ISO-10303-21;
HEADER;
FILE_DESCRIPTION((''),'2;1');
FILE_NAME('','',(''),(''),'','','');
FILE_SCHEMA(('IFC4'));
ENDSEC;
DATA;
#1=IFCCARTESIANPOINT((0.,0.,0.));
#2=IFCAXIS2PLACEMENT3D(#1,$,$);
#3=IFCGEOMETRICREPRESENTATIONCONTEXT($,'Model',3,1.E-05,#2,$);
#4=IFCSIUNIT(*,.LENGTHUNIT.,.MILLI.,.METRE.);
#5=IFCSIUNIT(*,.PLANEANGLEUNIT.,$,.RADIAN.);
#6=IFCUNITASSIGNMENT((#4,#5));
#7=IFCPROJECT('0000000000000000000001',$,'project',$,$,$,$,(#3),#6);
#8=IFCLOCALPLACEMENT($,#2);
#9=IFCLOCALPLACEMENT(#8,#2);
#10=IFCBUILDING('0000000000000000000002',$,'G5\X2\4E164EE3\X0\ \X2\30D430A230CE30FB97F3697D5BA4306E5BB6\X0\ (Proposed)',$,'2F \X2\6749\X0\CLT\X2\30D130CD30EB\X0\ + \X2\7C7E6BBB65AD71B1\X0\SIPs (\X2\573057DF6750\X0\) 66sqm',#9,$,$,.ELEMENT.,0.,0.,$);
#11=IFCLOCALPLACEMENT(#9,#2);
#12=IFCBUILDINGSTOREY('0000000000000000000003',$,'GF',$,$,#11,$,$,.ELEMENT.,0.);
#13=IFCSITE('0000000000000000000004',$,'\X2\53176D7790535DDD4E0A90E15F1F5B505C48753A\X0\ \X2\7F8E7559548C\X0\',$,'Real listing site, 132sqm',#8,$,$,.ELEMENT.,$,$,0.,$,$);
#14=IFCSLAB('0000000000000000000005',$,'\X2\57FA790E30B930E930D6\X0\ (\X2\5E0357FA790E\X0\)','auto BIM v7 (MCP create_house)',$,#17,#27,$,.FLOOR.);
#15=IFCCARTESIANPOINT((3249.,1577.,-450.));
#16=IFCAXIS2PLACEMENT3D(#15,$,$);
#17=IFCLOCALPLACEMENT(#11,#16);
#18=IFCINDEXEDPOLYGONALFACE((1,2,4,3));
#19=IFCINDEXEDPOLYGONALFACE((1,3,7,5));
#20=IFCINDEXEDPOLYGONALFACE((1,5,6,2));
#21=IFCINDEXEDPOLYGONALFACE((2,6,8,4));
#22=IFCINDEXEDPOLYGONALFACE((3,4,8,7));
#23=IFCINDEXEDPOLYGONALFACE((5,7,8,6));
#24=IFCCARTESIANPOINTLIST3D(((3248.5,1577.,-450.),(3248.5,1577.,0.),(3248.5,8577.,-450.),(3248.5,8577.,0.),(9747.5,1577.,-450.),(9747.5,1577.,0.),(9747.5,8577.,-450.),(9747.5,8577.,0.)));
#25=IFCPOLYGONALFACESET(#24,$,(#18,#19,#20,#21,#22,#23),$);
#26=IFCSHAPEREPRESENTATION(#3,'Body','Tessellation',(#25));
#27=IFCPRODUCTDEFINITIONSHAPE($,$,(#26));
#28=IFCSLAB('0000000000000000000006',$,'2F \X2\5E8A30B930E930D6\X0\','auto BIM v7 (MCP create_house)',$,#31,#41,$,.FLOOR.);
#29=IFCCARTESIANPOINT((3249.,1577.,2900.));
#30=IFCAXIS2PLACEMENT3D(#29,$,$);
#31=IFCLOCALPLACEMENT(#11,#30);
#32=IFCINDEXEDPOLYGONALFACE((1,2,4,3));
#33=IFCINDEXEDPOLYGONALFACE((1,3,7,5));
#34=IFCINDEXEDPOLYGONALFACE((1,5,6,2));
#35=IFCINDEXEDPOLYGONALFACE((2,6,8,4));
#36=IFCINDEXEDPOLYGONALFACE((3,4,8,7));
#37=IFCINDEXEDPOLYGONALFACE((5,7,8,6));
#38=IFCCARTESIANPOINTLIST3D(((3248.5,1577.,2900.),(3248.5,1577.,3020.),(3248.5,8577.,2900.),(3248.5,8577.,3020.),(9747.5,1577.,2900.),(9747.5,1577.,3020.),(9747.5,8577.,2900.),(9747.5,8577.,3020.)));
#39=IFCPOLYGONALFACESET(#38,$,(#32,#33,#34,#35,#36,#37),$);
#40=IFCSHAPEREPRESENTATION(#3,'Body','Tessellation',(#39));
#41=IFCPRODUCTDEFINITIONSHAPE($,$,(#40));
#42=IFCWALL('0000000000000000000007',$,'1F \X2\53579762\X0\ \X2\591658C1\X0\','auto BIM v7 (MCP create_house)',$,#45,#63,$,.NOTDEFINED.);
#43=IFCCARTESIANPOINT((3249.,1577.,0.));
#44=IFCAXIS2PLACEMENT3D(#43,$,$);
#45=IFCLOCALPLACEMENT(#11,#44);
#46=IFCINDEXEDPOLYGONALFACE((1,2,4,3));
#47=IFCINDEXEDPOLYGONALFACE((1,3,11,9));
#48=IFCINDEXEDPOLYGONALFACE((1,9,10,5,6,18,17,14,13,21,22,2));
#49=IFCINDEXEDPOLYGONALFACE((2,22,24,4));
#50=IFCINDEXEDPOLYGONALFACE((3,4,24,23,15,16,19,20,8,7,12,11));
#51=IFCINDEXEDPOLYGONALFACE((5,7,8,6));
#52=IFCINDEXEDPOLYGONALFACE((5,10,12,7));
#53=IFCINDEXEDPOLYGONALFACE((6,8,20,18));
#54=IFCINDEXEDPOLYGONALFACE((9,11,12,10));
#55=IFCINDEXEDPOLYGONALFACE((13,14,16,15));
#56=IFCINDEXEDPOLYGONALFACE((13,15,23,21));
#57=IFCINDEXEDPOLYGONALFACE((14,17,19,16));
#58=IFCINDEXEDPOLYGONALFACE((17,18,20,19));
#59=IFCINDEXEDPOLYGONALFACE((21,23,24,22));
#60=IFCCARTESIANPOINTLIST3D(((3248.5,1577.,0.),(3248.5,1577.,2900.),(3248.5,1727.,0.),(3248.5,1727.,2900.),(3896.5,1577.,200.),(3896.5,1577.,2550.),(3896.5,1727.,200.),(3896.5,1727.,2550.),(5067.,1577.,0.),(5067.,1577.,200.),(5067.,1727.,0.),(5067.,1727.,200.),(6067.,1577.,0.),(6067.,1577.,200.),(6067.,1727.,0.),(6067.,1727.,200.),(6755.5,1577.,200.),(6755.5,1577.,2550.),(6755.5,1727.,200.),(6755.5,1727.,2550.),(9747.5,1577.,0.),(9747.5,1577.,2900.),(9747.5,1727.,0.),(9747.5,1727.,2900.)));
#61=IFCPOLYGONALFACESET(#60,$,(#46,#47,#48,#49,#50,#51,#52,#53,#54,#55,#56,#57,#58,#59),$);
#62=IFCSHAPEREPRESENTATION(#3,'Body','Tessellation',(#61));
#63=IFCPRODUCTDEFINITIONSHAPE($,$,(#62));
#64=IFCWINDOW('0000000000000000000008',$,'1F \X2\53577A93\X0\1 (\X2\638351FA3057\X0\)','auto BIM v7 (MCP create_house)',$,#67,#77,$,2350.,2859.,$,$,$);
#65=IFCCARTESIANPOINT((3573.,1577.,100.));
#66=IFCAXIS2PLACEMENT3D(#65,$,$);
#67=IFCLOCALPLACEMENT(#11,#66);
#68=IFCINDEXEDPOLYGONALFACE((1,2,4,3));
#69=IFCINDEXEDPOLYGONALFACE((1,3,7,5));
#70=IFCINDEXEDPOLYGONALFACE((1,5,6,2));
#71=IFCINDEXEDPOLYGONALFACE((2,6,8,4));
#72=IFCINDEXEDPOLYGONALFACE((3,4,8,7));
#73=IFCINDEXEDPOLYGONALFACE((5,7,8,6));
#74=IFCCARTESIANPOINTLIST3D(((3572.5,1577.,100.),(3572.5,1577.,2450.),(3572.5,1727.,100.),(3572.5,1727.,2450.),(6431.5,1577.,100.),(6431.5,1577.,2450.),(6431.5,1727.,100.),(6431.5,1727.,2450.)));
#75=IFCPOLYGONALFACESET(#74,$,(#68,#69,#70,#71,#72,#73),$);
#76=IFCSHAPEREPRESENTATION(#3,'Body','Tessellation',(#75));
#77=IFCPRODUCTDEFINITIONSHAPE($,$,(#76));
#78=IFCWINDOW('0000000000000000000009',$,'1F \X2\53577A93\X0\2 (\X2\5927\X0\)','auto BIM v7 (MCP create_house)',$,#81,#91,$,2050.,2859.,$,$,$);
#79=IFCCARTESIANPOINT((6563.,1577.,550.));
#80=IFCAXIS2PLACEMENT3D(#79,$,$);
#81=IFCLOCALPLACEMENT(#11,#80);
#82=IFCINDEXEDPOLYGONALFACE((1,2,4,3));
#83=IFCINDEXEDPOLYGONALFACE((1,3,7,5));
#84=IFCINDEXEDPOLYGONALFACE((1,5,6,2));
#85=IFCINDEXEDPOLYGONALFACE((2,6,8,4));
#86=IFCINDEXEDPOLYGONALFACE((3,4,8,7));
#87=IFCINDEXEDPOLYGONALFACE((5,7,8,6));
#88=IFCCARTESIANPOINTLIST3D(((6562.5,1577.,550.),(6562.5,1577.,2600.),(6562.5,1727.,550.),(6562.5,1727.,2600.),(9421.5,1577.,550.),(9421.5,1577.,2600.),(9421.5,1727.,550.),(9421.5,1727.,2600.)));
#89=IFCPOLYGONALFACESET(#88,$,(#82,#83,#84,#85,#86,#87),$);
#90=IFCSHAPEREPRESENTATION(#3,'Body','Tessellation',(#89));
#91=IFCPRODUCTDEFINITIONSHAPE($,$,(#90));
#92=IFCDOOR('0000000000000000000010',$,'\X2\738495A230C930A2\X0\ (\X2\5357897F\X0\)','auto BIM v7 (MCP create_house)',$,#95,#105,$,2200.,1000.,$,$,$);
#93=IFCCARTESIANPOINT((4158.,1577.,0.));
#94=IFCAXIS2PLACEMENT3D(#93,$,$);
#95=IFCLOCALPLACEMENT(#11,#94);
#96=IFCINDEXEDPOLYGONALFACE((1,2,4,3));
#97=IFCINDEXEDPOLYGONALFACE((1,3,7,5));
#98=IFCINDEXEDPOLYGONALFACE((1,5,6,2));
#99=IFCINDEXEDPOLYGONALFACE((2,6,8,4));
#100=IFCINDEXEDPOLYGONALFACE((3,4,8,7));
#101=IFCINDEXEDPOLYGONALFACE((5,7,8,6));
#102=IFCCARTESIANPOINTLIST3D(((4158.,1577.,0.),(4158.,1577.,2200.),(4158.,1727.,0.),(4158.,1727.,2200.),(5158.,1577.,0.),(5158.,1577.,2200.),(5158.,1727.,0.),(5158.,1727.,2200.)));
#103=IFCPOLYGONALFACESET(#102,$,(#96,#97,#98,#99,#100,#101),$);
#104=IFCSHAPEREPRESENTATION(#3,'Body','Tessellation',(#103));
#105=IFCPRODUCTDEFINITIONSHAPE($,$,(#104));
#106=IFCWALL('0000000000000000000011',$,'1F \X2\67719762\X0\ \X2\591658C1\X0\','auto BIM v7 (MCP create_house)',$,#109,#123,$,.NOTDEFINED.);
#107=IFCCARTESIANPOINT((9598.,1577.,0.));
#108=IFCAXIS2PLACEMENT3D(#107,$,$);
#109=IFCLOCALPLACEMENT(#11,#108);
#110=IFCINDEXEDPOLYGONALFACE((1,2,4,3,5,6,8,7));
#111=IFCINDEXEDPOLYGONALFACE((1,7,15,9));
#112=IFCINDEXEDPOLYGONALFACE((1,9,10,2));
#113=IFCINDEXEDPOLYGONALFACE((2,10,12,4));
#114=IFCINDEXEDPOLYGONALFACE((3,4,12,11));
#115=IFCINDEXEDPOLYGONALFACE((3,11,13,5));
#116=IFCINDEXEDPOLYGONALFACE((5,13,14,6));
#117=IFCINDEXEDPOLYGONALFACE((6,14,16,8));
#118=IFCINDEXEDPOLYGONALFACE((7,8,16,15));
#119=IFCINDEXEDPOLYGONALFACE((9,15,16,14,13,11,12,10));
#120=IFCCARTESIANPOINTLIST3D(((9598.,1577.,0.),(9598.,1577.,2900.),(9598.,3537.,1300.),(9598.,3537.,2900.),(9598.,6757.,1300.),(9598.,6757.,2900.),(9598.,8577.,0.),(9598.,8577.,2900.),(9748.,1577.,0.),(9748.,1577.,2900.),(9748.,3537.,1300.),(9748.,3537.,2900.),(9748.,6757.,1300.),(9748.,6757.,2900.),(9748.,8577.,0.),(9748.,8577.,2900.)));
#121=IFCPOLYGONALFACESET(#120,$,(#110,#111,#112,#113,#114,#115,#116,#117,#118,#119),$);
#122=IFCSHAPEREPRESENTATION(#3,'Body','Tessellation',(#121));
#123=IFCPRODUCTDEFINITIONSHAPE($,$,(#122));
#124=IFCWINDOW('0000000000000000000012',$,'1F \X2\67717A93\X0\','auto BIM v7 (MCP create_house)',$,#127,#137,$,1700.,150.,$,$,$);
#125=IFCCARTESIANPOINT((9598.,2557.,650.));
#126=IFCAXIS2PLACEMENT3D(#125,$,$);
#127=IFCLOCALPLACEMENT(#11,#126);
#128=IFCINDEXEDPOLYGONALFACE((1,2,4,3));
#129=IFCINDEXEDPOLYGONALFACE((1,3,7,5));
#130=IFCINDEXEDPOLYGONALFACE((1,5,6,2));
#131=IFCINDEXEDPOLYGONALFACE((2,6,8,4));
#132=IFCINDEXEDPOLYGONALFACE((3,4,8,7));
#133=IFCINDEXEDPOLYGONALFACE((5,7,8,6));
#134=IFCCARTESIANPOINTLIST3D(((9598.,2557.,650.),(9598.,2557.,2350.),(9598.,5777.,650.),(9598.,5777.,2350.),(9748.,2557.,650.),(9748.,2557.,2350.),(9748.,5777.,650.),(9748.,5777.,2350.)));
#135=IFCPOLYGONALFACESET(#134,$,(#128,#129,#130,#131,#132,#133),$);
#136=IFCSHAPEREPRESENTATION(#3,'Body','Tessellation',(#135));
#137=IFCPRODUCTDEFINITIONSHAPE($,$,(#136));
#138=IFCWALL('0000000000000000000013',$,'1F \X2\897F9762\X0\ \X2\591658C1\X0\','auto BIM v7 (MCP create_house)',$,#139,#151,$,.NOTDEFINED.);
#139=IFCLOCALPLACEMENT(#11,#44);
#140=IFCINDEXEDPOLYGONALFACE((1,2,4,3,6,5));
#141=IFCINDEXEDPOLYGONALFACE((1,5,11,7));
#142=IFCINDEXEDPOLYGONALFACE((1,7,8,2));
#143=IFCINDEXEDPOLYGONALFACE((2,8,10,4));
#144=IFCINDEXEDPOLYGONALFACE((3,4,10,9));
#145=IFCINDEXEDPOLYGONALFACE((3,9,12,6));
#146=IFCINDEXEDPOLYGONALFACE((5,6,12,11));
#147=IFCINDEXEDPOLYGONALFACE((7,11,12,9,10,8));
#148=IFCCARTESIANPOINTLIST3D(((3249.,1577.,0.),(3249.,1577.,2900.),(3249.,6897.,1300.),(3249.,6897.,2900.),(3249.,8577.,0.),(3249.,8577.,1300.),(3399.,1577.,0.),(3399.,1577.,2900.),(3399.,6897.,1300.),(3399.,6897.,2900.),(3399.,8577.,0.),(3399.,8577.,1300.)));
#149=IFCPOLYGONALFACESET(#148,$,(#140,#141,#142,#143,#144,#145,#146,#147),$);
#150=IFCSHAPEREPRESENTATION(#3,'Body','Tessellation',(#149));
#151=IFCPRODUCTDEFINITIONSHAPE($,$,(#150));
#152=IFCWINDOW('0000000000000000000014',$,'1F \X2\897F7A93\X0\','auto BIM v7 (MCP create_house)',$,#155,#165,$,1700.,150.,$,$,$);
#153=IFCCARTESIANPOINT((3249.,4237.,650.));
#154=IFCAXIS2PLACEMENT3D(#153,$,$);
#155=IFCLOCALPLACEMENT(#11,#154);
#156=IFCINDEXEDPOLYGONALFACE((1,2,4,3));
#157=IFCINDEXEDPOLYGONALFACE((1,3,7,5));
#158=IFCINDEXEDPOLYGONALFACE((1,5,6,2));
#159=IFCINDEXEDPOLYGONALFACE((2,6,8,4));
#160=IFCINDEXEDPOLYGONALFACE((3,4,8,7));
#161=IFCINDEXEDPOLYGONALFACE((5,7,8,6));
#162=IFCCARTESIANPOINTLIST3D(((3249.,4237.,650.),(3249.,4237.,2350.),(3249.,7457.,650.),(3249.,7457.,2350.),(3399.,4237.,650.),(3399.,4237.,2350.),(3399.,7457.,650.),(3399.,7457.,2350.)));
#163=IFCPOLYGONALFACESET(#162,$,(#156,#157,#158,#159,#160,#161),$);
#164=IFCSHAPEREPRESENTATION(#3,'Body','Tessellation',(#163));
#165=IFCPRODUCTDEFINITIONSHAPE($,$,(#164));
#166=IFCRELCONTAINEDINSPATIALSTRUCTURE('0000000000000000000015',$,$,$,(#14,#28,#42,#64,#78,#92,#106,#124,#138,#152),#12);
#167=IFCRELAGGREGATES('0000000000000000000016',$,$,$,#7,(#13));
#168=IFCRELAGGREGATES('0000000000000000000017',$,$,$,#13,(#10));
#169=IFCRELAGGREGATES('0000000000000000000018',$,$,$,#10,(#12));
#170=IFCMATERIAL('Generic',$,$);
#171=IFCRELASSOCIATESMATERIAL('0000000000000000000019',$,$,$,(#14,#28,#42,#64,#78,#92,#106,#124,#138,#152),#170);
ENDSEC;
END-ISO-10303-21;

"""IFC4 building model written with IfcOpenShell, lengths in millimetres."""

from ifc_helpers import new_model, si_unit, frame, frame_2d, origin, place, context, project, spatial, rectangle, extrude, material, element, fill, save


model = new_model("IFC4")

# Units and contexts
model_context = context("Model", 3, precision=1e-05, world=origin())
ifc_project = project(units=[si_unit("LENGTHUNIT", "METRE", prefix="MILLI"), si_unit("PLANEANGLEUNIT", "RADIAN")], contexts=[model_context])

# Site, building, storey
site_placement = place(None, origin())
site = spatial("IfcSite", under=ifc_project, at=site_placement, Name="北海道川上郡弟子屈町 美留和", ObjectType="Real listing site, 132sqm", CompositionType="ELEMENT", RefElevation=0.0)
building_placement = place(site_placement, origin())
building = spatial("IfcBuilding", under=site, at=building_placement, Name="G5世代 ピアノ・音楽室の家 (Proposed)", ObjectType="2F 杉CLTパネル + 籾殻断熱SIPs (地域材) 66sqm", CompositionType="ELEMENT", ElevationOfRefHeight=0.0, ElevationOfTerrain=0.0)
storey_placement = place(building_placement, origin())
storey = spatial("IfcBuildingStorey", under=building, at=storey_placement, Name="GF", CompositionType="ELEMENT", Elevation=0.0)

# Slabs
ifc_material = material(Name="Generic")
slab_1_placement = place(storey_placement, frame((3249.0, 1577.0, -450.0)))
element("IfcSlab", 1, at=slab_1_placement, inside=storey, material=ifc_material, Name="基礎スラブ (布基礎)", Description="auto BIM v7 (MCP create_house)", PredefinedType="FLOOR", context=model_context, shape_type="SweptSolid", body=[
    extrude(rectangle(XDim=6499.0, YDim=7000.0, at=frame_2d((3249.0, 3500.0))), frame((3249.0, 1577.0, -450.0)), (0.0, 0.0, 1.0), 450.0),
])
slab_2_placement = place(storey_placement, frame((3249.0, 1577.0, 2900.0)))
element("IfcSlab", 2, at=slab_2_placement, inside=storey, material=ifc_material, Name="2F 床スラブ", Description="auto BIM v7 (MCP create_house)", PredefinedType="FLOOR", context=model_context, shape_type="SweptSolid", body=[
    extrude(rectangle(XDim=6499.0, YDim=7000.0, at=frame_2d((3249.0, 3500.0))), frame((3249.0, 1577.0, 2900.0)), (0.0, 0.0, 1.0), 120.0),
])

# Wall, openings, windows, door
wall_1_placement = place(storey_placement, frame((3249.0, 1577.0, 0.0)))
wall_1 = element("IfcWall", 3, at=wall_1_placement, inside=storey, material=ifc_material, Name="1F 南面 外壁", Description="auto BIM v7 (MCP create_house)", PredefinedType="NOTDEFINED", context=model_context, shape_type="SweptSolid", body=[
    extrude(rectangle(XDim=6499.0, YDim=150.0, at=frame_2d((3249.0, 75.0))), frame((3249.0, 1577.0, 0.0)), (0.0, 0.0, 1.0), 2900.0),
])
opening_1_placement = place(storey_placement, frame((3573.0, 1577.0, 100.0)))
opening_1 = element("IfcOpeningElement", 4, at=opening_1_placement, cuts=wall_1, PredefinedType="NOTDEFINED", context=model_context, shape_type="SweptSolid", body=[
    extrude(rectangle(XDim=2859.0, YDim=150.0, at=frame_2d((1429.0, 75.0))), frame((3573.0, 1577.0, 100.0)), (0.0, 0.0, 1.0), 2350.0),
])
opening_2_placement = place(storey_placement, frame((6563.0, 1577.0, 550.0)))
opening_2 = element("IfcOpeningElement", 5, at=opening_2_placement, cuts=wall_1, PredefinedType="NOTDEFINED", context=model_context, shape_type="SweptSolid", body=[
    extrude(rectangle(XDim=2859.0, YDim=150.0, at=frame_2d((1429.0, 75.0))), frame((6563.0, 1577.0, 550.0)), (0.0, 0.0, 1.0), 2050.0),
])
opening_3_placement = place(storey_placement, frame((4158.0, 1577.0, 0.0)))
opening_3 = element("IfcOpeningElement", 6, at=opening_3_placement, cuts=wall_1, PredefinedType="NOTDEFINED", context=model_context, shape_type="SweptSolid", body=[
    extrude(rectangle(XDim=1000.0, YDim=150.0, at=frame_2d((500.0, 75.0))), frame((4158.0, 1577.0, 0.0)), (0.0, 0.0, 1.0), 2200.0),
])
window_1_placement = place(storey_placement, frame((3573.0, 1577.0, 100.0)))
window_1 = element("IfcWindow", 7, at=window_1_placement, inside=storey, material=ifc_material, Name="1F 南窓1 (掃出し)", Description="auto BIM v7 (MCP create_house)", OverallHeight=2350.0, OverallWidth=2859.0, context=model_context, shape_type="SweptSolid", body=[
    extrude(rectangle(XDim=2859.0, YDim=150.0, at=frame_2d((1429.0, 75.0))), frame((3573.0, 1577.0, 100.0)), (0.0, 0.0, 1.0), 2350.0),
])
fill(opening_1, window_1)
window_2_placement = place(storey_placement, frame((6563.0, 1577.0, 550.0)))
window_2 = element("IfcWindow", 8, at=window_2_placement, inside=storey, material=ifc_material, Name="1F 南窓2 (大)", Description="auto BIM v7 (MCP create_house)", OverallHeight=2050.0, OverallWidth=2859.0, context=model_context, shape_type="SweptSolid", body=[
    extrude(rectangle(XDim=2859.0, YDim=150.0, at=frame_2d((1429.0, 75.0))), frame((6563.0, 1577.0, 550.0)), (0.0, 0.0, 1.0), 2050.0),
])
fill(opening_2, window_2)
door_placement = place(storey_placement, frame((4158.0, 1577.0, 0.0)))
door = element("IfcDoor", 9, at=door_placement, inside=storey, material=ifc_material, Name="玄関ドア (南西)", Description="auto BIM v7 (MCP create_house)", OverallHeight=2200.0, OverallWidth=1000.0, context=model_context, shape_type="SweptSolid", body=[
    extrude(rectangle(XDim=1000.0, YDim=150.0, at=frame_2d((500.0, 75.0))), frame((4158.0, 1577.0, 0.0)), (0.0, 0.0, 1.0), 2200.0),
])
fill(opening_3, door)

# Walls, openings, windows
wall_2_placement = place(storey_placement, frame((9598.0, 1577.0, 0.0)))
wall_2 = element("IfcWall", 10, at=wall_2_placement, inside=storey, material=ifc_material, Name="1F 東面 外壁", Description="auto BIM v7 (MCP create_house)", PredefinedType="NOTDEFINED", context=model_context, shape_type="SweptSolid", body=[
    extrude(rectangle(XDim=150.0, YDim=7000.0, at=frame_2d((75.0, 3500.0))), frame((9598.0, 1577.0, 0.0)), (0.0, 0.0, 1.0), 2900.0),
])
opening_4_placement = place(storey_placement, frame((9598.0, 2557.0, 650.0)))
opening_4 = element("IfcOpeningElement", 11, at=opening_4_placement, cuts=wall_2, PredefinedType="NOTDEFINED", context=model_context, shape_type="SweptSolid", body=[
    extrude(rectangle(XDim=150.0, YDim=3220.0, at=frame_2d((75.0, 1610.0))), frame((9598.0, 2557.0, 650.0)), (0.0, 0.0, 1.0), 1700.0),
])
window_3_placement = place(storey_placement, frame((9598.0, 2557.0, 650.0)))
window_3 = element("IfcWindow", 12, at=window_3_placement, inside=storey, material=ifc_material, Name="1F 東窓", Description="auto BIM v7 (MCP create_house)", OverallHeight=1700.0, OverallWidth=150.0, context=model_context, shape_type="SweptSolid", body=[
    extrude(rectangle(XDim=150.0, YDim=3220.0, at=frame_2d((75.0, 1610.0))), frame((9598.0, 2557.0, 650.0)), (0.0, 0.0, 1.0), 1700.0),
])
fill(opening_4, window_3)
wall_3_placement = place(storey_placement, frame((3249.0, 1577.0, 0.0)))
wall_3 = element("IfcWall", 13, at=wall_3_placement, inside=storey, material=ifc_material, Name="1F 西面 外壁", Description="auto BIM v7 (MCP create_house)", PredefinedType="NOTDEFINED", context=model_context, shape_type="SweptSolid", body=[
    extrude(rectangle(XDim=150.0, YDim=7000.0, at=frame_2d((75.0, 3500.0))), frame((3249.0, 1577.0, 0.0)), (0.0, 0.0, 1.0), 2900.0),
])
opening_5_placement = place(storey_placement, frame((3249.0, 4237.0, 650.0)))
opening_5 = element("IfcOpeningElement", 14, at=opening_5_placement, cuts=wall_3, PredefinedType="NOTDEFINED", context=model_context, shape_type="SweptSolid", body=[
    extrude(rectangle(XDim=150.0, YDim=3220.0, at=frame_2d((75.0, 1610.0))), frame((3249.0, 4237.0, 650.0)), (0.0, 0.0, 1.0), 1700.0),
])
window_4_placement = place(storey_placement, frame((3249.0, 4237.0, 650.0)))
window_4 = element("IfcWindow", 15, at=window_4_placement, inside=storey, material=ifc_material, Name="1F 西窓", Description="auto BIM v7 (MCP create_house)", OverallHeight=1700.0, OverallWidth=150.0, context=model_context, shape_type="SweptSolid", body=[
    extrude(rectangle(XDim=150.0, YDim=3220.0, at=frame_2d((75.0, 1610.0))), frame((3249.0, 4237.0, 650.0)), (0.0, 0.0, 1.0), 1700.0),
])
fill(opening_5, window_4)

save(model, "model.ifc")
